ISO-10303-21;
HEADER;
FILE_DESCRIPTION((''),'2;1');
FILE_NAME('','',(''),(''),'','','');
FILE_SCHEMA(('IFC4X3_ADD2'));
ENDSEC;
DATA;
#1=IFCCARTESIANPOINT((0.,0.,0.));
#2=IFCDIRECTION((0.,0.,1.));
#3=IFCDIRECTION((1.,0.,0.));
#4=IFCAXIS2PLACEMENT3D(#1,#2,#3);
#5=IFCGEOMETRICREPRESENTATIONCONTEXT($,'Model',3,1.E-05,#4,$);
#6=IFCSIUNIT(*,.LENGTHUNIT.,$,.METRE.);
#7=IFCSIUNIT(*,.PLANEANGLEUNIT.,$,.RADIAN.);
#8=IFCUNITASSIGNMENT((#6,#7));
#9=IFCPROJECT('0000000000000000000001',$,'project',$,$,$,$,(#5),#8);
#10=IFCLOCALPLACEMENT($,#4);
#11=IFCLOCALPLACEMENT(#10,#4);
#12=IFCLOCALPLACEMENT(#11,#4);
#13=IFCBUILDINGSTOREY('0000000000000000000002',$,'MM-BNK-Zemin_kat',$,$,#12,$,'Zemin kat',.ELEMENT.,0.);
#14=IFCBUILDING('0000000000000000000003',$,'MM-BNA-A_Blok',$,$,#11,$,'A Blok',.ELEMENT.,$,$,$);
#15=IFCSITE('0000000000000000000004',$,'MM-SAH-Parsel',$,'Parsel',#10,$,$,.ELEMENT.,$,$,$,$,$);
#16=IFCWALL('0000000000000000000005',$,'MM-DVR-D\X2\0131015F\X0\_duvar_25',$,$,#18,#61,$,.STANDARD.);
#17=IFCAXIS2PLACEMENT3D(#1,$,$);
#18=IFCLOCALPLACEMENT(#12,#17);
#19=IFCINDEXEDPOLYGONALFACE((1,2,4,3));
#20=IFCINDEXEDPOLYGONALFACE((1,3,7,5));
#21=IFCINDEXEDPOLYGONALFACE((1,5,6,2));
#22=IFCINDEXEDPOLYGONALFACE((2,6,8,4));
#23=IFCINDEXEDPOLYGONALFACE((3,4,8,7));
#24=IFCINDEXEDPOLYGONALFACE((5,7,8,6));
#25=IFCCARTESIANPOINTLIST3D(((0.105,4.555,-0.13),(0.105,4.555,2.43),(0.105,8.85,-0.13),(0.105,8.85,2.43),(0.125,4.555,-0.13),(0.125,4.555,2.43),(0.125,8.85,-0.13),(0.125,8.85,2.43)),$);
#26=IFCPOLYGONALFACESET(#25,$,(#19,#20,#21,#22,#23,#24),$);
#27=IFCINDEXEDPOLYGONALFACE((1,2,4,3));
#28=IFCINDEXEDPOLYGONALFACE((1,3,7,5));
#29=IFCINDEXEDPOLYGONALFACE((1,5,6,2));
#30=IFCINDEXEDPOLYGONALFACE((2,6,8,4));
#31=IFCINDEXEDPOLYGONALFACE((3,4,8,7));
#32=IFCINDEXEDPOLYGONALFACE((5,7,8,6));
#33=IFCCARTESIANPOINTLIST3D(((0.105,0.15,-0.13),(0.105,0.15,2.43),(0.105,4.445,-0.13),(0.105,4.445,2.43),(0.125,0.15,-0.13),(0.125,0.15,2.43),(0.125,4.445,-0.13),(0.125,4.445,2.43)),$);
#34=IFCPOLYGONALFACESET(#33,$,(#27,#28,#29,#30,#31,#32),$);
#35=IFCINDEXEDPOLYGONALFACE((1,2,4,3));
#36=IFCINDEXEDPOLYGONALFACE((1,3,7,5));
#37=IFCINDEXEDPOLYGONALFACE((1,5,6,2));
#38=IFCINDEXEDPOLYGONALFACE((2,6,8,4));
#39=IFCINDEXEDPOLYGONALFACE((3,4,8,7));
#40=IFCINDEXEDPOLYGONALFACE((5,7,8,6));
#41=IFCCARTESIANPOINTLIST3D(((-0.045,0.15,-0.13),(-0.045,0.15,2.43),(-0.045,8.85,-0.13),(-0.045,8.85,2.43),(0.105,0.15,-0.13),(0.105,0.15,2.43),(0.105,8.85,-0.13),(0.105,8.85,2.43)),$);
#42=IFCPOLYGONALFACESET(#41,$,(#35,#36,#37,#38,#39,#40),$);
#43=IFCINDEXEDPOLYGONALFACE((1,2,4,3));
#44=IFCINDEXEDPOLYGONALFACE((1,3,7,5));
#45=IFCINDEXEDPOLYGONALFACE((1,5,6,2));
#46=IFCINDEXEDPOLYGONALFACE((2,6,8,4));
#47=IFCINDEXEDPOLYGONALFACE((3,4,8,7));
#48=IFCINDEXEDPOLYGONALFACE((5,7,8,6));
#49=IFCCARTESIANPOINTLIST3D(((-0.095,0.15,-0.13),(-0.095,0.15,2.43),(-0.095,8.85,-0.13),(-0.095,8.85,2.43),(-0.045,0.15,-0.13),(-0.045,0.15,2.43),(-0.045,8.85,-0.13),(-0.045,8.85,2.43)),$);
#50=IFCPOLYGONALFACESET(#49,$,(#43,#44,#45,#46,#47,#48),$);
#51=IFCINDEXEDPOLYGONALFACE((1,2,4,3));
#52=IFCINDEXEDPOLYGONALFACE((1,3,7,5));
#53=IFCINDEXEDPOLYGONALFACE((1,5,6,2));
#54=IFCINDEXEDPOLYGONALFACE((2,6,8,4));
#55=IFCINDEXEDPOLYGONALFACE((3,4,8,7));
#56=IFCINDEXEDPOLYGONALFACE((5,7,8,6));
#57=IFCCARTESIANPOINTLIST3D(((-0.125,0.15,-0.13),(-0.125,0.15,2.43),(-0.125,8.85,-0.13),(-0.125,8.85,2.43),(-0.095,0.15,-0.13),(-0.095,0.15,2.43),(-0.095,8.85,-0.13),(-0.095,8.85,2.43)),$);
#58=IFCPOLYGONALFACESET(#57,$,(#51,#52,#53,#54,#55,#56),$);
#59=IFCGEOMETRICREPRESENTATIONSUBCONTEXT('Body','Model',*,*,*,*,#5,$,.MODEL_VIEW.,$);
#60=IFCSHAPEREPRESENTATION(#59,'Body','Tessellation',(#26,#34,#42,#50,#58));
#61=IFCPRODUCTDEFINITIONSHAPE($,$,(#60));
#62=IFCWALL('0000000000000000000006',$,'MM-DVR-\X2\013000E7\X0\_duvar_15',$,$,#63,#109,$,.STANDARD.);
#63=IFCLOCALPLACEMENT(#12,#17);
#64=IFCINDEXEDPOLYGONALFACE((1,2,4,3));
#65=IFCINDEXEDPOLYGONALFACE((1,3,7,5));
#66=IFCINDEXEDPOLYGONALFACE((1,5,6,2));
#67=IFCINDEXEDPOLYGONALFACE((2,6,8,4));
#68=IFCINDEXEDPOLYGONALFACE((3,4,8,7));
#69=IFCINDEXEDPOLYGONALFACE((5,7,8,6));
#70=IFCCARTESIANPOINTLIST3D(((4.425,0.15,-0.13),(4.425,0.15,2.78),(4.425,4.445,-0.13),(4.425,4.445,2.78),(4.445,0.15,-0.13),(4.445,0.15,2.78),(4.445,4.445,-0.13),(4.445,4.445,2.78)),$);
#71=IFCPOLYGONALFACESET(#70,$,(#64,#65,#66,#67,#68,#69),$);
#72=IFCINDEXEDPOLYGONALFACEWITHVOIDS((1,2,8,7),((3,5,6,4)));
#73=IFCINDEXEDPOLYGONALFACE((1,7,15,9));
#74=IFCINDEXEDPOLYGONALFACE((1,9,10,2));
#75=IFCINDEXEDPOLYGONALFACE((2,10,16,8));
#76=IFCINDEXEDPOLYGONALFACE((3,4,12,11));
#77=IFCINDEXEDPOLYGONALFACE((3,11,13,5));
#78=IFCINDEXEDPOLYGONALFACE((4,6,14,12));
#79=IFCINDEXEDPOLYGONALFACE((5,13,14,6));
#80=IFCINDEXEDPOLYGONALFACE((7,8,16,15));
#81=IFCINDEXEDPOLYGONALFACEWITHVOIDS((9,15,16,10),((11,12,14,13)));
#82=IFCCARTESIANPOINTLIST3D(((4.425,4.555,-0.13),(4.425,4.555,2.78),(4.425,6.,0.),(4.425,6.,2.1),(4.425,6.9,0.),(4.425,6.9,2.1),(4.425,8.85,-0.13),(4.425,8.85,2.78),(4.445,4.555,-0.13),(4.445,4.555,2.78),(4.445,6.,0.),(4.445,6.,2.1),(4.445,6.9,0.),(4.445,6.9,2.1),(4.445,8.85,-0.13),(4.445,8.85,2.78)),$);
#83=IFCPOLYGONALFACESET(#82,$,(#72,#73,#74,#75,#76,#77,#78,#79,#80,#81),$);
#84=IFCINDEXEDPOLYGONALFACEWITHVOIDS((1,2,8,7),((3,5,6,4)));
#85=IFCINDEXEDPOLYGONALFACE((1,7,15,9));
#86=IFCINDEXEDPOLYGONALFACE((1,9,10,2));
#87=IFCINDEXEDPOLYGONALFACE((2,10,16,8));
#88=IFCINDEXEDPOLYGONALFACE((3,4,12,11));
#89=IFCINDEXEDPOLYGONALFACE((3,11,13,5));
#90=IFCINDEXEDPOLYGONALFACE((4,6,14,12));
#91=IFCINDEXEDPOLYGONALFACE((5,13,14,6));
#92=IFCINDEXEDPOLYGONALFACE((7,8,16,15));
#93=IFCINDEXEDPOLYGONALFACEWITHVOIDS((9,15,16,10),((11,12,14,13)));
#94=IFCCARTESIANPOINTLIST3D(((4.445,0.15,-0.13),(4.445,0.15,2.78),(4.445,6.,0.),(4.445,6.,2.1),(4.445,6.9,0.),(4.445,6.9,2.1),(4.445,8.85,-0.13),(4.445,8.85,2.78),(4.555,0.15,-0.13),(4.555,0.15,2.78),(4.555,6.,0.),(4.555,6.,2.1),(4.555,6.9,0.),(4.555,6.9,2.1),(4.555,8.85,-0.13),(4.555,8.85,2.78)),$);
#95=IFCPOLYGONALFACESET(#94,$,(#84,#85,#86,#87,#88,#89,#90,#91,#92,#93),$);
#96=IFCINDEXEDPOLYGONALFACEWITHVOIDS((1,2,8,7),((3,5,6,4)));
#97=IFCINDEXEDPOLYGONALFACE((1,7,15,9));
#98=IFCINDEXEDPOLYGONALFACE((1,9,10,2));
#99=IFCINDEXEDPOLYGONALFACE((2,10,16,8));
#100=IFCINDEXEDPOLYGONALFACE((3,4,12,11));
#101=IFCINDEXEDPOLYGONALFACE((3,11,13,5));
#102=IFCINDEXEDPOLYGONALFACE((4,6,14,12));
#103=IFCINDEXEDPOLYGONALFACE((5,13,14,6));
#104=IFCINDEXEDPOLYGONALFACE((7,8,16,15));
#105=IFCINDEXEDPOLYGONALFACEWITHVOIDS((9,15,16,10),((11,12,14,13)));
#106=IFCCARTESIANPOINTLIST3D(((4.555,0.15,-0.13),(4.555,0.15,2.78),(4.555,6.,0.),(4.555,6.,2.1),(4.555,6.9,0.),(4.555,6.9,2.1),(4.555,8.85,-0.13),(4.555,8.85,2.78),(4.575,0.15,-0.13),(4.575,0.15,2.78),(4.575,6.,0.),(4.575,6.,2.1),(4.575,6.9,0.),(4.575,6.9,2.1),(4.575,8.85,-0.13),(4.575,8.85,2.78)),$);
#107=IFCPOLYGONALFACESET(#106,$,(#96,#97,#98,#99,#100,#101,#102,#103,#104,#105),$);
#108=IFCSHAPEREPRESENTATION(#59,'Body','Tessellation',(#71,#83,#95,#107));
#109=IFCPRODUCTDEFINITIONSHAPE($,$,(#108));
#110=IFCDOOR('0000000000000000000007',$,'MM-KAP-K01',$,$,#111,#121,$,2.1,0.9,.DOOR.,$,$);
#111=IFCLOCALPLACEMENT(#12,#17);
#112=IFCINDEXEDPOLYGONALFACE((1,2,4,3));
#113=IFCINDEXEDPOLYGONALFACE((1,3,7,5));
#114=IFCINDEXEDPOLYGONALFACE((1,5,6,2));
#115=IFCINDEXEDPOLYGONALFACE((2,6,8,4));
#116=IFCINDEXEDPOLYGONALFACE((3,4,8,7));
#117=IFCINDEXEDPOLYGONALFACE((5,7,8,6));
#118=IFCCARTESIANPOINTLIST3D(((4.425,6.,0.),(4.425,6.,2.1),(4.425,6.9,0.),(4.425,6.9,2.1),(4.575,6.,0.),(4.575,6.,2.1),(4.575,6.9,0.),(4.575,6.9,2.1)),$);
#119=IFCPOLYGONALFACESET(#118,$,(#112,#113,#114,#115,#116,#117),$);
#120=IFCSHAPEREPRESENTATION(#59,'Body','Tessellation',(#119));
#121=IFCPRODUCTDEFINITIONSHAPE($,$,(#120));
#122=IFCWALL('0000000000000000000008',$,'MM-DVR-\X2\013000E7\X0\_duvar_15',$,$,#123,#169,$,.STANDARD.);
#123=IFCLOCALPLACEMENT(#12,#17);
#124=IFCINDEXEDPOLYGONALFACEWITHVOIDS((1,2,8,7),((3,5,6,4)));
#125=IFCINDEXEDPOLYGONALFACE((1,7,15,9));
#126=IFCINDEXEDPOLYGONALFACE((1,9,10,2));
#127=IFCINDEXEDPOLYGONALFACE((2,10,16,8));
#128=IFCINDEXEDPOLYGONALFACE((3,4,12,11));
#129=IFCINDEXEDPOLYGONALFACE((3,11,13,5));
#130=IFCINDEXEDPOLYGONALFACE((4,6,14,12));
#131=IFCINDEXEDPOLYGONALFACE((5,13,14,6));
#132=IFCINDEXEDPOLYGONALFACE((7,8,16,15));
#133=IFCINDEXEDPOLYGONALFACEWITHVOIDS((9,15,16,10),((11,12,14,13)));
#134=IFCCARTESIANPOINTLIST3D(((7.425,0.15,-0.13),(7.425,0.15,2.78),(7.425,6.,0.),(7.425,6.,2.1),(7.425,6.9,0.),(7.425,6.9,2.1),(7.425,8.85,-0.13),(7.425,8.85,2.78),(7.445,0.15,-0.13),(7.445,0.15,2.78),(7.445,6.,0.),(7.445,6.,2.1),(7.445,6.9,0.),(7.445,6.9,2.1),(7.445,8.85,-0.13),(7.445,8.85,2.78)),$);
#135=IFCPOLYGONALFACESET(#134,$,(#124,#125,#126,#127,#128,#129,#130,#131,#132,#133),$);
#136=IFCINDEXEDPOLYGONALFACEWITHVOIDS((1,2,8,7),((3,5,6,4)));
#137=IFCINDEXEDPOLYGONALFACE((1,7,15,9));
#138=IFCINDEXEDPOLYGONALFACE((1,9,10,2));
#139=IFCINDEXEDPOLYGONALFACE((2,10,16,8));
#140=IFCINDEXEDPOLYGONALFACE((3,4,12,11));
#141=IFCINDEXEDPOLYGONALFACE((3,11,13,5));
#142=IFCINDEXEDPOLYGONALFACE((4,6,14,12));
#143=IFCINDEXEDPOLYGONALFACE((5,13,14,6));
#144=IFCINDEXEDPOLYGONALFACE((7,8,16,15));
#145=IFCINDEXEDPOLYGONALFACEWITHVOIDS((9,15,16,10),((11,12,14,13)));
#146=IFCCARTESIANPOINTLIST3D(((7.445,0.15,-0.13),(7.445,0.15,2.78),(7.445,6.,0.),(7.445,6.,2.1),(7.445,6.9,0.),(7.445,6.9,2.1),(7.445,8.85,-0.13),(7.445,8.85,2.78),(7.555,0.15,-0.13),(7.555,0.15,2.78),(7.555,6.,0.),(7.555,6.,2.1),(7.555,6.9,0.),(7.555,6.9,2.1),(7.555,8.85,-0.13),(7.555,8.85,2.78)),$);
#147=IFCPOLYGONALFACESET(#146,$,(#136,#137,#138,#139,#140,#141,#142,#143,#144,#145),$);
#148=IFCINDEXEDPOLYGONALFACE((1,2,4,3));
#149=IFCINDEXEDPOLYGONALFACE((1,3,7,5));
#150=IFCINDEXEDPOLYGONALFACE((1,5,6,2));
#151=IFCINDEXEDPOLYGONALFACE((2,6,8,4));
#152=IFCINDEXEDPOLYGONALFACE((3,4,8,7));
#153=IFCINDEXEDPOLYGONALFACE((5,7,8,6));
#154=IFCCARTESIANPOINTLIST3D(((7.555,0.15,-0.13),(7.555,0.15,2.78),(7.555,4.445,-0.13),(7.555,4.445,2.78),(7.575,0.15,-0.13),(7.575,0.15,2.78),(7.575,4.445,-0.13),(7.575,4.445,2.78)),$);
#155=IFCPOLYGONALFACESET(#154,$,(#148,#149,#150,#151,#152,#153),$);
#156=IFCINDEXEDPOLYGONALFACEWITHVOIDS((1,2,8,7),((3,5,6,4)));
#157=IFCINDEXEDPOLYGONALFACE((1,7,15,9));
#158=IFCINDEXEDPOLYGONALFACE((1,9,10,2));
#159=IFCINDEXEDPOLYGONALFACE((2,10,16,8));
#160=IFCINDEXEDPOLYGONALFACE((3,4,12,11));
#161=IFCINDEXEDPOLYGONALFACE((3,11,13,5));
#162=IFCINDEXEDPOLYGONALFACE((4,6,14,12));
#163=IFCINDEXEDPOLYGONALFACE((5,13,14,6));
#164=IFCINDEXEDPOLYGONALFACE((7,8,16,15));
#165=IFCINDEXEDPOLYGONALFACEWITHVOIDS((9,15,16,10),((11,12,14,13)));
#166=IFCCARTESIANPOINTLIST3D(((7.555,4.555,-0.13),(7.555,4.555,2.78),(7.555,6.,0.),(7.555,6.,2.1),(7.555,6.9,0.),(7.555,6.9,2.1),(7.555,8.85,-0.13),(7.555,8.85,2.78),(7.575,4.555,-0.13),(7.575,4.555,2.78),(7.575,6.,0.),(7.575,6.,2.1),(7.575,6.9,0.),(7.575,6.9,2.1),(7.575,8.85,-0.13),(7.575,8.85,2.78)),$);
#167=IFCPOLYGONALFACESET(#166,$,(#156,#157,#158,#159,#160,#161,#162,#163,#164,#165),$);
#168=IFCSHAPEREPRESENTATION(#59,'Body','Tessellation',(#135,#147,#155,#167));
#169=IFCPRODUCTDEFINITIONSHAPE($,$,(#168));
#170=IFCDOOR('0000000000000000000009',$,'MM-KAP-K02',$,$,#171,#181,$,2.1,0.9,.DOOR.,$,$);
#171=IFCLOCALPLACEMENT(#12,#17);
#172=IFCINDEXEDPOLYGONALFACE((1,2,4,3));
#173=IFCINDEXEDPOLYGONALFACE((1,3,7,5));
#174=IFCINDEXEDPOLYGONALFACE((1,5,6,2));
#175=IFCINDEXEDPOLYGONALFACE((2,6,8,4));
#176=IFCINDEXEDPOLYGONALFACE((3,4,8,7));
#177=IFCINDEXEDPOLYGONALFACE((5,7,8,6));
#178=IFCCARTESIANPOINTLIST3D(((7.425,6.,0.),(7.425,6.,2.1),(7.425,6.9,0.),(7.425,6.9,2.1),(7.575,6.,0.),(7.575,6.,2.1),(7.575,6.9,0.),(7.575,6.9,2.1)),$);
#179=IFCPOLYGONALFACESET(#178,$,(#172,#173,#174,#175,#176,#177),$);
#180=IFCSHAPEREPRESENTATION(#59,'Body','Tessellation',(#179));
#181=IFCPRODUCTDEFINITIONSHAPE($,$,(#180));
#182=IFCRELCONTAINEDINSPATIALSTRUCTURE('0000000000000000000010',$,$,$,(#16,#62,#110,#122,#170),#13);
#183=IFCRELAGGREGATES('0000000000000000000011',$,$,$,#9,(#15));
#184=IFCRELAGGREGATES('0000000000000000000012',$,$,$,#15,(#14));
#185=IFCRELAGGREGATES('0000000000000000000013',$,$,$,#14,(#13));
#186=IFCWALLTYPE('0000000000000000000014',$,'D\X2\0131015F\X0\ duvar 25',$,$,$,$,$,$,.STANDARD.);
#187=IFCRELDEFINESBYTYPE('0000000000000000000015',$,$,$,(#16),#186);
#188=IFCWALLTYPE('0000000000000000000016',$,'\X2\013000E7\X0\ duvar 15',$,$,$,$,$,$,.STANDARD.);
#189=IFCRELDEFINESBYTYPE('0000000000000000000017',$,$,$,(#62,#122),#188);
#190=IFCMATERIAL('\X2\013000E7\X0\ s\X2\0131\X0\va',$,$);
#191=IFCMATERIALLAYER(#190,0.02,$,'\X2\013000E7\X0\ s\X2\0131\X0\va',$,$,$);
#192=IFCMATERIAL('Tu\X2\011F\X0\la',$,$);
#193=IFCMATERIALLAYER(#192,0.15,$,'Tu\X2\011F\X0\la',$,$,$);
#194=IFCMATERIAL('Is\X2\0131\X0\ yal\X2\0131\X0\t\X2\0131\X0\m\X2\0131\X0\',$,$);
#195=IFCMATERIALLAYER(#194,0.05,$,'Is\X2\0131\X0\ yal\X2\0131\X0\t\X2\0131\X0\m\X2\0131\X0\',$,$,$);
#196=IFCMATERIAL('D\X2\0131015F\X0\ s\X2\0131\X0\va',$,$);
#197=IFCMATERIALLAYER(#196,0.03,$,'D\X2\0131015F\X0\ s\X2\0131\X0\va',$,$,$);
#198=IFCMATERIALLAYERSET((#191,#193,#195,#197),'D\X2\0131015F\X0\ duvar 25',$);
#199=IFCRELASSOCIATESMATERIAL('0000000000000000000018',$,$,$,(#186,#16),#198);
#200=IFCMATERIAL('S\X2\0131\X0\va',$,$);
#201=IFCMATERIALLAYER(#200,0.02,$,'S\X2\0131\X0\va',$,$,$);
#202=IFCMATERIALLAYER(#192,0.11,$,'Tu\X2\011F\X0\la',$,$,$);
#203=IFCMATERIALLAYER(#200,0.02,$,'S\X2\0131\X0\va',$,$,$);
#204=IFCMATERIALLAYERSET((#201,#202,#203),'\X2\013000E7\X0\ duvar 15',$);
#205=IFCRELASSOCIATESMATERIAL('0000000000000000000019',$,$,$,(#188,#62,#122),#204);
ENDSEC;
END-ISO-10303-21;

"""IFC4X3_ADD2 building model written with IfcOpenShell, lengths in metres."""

from ifc_helpers import new_model, si_unit, frame, origin, origin_with_axes, place, context, subcontext, project, spatial, polyline, outline, extrude, material, layer, layer_set, type_object, element, fill, save


model = new_model("IFC4X3_ADD2")

# Units and contexts
model_context = context("Model", 3, precision=1e-05, world=origin_with_axes())
body_context = subcontext(model_context, "Body", "Model", "MODEL_VIEW")
ifc_project = project(units=[si_unit("LENGTHUNIT", "METRE"), si_unit("PLANEANGLEUNIT", "RADIAN")], contexts=[model_context])

# Site, building, storey
site_placement = place(None, origin_with_axes())
site = spatial("IfcSite", under=ifc_project, at=site_placement, Name="MM-SAH-Parsel", ObjectType="Parsel", CompositionType="ELEMENT")
building_placement = place(site_placement, origin_with_axes())
building = spatial("IfcBuilding", under=site, at=building_placement, Name="MM-BNA-A_Blok", LongName="A Blok", CompositionType="ELEMENT")
storey_placement = place(building_placement, origin_with_axes())
storey = spatial("IfcBuildingStorey", under=building, at=storey_placement, Name="MM-BNK-Zemin_kat", LongName="Zemin kat", CompositionType="ELEMENT", Elevation=0.0)

# Shared definitions
ifc_material_1 = material(Name="İç sıva")
ifc_layer_1 = layer(ifc_material_1, 0.02, Name="İç sıva")
ifc_material_2 = material(Name="Tuğla")
ifc_layer_2 = layer(ifc_material_2, 0.15, Name="Tuğla")
ifc_material_3 = material(Name="Isı yalıtımı")
ifc_layer_3 = layer(ifc_material_3, 0.05, Name="Isı yalıtımı")
ifc_material_4 = material(Name="Dış sıva")
ifc_layer_4 = layer(ifc_material_4, 0.03, Name="Dış sıva")
ifc_layer_set_1 = layer_set([ifc_layer_1, ifc_layer_2, ifc_layer_3, ifc_layer_4], Name="Dış duvar 25")
wall_type_1 = type_object("IfcWallType", Name="Dış duvar 25", PredefinedType="STANDARD", material=ifc_layer_set_1)

# Wall
wall_1_placement = place(storey_placement, origin_with_axes())
element("IfcWall", 1, at=wall_1_placement, inside=storey, type_object=wall_type_1, material=ifc_layer_set_1, Name="MM-DVR-Dış_duvar_25", PredefinedType="STANDARD", context=body_context, shape_type="SweptSolid", body=[
    extrude(outline(polyline([(0.105, 8.85), (0.105, 4.555), (0.125, 4.555), (0.125, 8.85), (0.105, 8.85)])), frame((0.0, 0.0, -0.13)), (0.0, 0.0, 1.0), 2.56),
    extrude(outline(polyline([(0.105, 4.445), (0.105, 0.15), (0.125, 0.15), (0.125, 4.445), (0.105, 4.445)])), frame((0.0, 0.0, -0.13)), (0.0, 0.0, 1.0), 2.56),
    extrude(outline(polyline([(-0.045, 8.85), (-0.045, 0.15), (0.105, 0.15), (0.105, 8.85), (-0.045, 8.85)])), frame((0.0, 0.0, -0.13)), (0.0, 0.0, 1.0), 2.56),
    extrude(outline(polyline([(-0.095, 8.85), (-0.095, 0.15), (-0.045, 0.15), (-0.045, 8.85), (-0.095, 8.85)])), frame((0.0, 0.0, -0.13)), (0.0, 0.0, 1.0), 2.56),
    extrude(outline(polyline([(-0.125, 8.85), (-0.125, 0.15), (-0.095, 0.15), (-0.095, 8.85), (-0.125, 8.85)])), frame((0.0, 0.0, -0.13)), (0.0, 0.0, 1.0), 2.56),
])

# Walls, openings, doors
ifc_material_5 = material(Name="Sıva")
ifc_layer_5 = layer(ifc_material_5, 0.02, Name="Sıva")
ifc_layer_6 = layer(ifc_material_2, 0.11, Name="Tuğla")
ifc_layer_7 = layer(ifc_material_5, 0.02, Name="Sıva")
ifc_layer_set_2 = layer_set([ifc_layer_5, ifc_layer_6, ifc_layer_7], Name="İç duvar 15")
wall_type_2 = type_object("IfcWallType", Name="İç duvar 15", PredefinedType="STANDARD", material=ifc_layer_set_2)
wall_2_placement = place(storey_placement, origin_with_axes())
wall_2 = element("IfcWall", 2, at=wall_2_placement, inside=storey, type_object=wall_type_2, material=ifc_layer_set_2, Name="MM-DVR-İç_duvar_15", PredefinedType="STANDARD", context=body_context, shape_type="SweptSolid", body=[
    extrude(outline(polyline([(4.445, 0.15), (4.445, 4.445), (4.425, 4.445), (4.425, 0.15), (4.445, 0.15)])), frame((0.0, 0.0, -0.13)), (0.0, 0.0, 1.0), 2.91),
    extrude(outline(polyline([(4.445, 4.555), (4.445, 8.85), (4.425, 8.85), (4.425, 4.555), (4.445, 4.555)])), frame((0.0, 0.0, -0.13)), (0.0, 0.0, 1.0), 2.91),
    extrude(outline(polyline([(4.555, 0.15), (4.555, 8.85), (4.445, 8.85), (4.445, 0.15), (4.555, 0.15)])), frame((0.0, 0.0, -0.13)), (0.0, 0.0, 1.0), 2.91),
    extrude(outline(polyline([(4.575, 0.15), (4.575, 8.85), (4.555, 8.85), (4.555, 0.15), (4.575, 0.15)])), frame((0.0, 0.0, -0.13)), (0.0, 0.0, 1.0), 2.91),
])
opening_1_placement = place(storey_placement, origin_with_axes())
opening_1 = element("IfcOpeningElement", 3, at=opening_1_placement, cuts=wall_2, PredefinedType="OPENING", context=body_context, shape_type="SweptSolid", body=[
    extrude(outline(polyline([(4.425, 6.0), (4.425, 6.9), (4.575, 6.9), (4.575, 6.0), (4.425, 6.0)])), origin(), (0.0, 0.0, 1.0), 2.1),
])
door_1_placement = place(storey_placement, origin_with_axes())
door_1 = element("IfcDoor", 4, at=door_1_placement, inside=storey, Name="MM-KAP-K01", OverallHeight=2.1, OverallWidth=0.9, PredefinedType="DOOR", context=body_context, shape_type="SweptSolid", body=[
    extrude(outline(polyline([(4.425, 6.0), (4.425, 6.9), (4.575, 6.9), (4.575, 6.0), (4.425, 6.0)])), origin(), (0.0, 0.0, 1.0), 2.1),
])
fill(opening_1, door_1)
wall_3_placement = place(storey_placement, origin_with_axes())
wall_3 = element("IfcWall", 5, at=wall_3_placement, inside=storey, type_object=wall_type_2, material=ifc_layer_set_2, Name="MM-DVR-İç_duvar_15", PredefinedType="STANDARD", context=body_context, shape_type="SweptSolid", body=[
    extrude(outline(polyline([(7.445, 0.15), (7.445, 8.85), (7.425, 8.85), (7.425, 0.15), (7.445, 0.15)])), frame((0.0, 0.0, -0.13)), (0.0, 0.0, 1.0), 2.91),
    extrude(outline(polyline([(7.555, 0.15), (7.555, 8.85), (7.445, 8.85), (7.445, 0.15), (7.555, 0.15)])), frame((0.0, 0.0, -0.13)), (0.0, 0.0, 1.0), 2.91),
    extrude(outline(polyline([(7.575, 0.15), (7.575, 4.445), (7.555, 4.445), (7.555, 0.15), (7.575, 0.15)])), frame((0.0, 0.0, -0.13)), (0.0, 0.0, 1.0), 2.91),
    extrude(outline(polyline([(7.575, 4.555), (7.575, 8.85), (7.555, 8.85), (7.555, 4.555), (7.575, 4.555)])), frame((0.0, 0.0, -0.13)), (0.0, 0.0, 1.0), 2.91),
])
opening_2_placement = place(storey_placement, origin_with_axes())
opening_2 = element("IfcOpeningElement", 6, at=opening_2_placement, cuts=wall_3, PredefinedType="OPENING", context=body_context, shape_type="SweptSolid", body=[
    extrude(outline(polyline([(7.425, 6.0), (7.425, 6.9), (7.575, 6.9), (7.575, 6.0), (7.425, 6.0)])), origin(), (0.0, 0.0, 1.0), 2.1),
])
door_2_placement = place(storey_placement, origin_with_axes())
door_2 = element("IfcDoor", 7, at=door_2_placement, inside=storey, Name="MM-KAP-K02", OverallHeight=2.1, OverallWidth=0.9, PredefinedType="DOOR", context=body_context, shape_type="SweptSolid", body=[
    extrude(outline(polyline([(7.425, 6.0), (7.425, 6.9), (7.575, 6.9), (7.575, 6.0), (7.425, 6.0)])), origin(), (0.0, 0.0, 1.0), 2.1),
])
fill(opening_2, door_2)

save(model, "model.ifc")
